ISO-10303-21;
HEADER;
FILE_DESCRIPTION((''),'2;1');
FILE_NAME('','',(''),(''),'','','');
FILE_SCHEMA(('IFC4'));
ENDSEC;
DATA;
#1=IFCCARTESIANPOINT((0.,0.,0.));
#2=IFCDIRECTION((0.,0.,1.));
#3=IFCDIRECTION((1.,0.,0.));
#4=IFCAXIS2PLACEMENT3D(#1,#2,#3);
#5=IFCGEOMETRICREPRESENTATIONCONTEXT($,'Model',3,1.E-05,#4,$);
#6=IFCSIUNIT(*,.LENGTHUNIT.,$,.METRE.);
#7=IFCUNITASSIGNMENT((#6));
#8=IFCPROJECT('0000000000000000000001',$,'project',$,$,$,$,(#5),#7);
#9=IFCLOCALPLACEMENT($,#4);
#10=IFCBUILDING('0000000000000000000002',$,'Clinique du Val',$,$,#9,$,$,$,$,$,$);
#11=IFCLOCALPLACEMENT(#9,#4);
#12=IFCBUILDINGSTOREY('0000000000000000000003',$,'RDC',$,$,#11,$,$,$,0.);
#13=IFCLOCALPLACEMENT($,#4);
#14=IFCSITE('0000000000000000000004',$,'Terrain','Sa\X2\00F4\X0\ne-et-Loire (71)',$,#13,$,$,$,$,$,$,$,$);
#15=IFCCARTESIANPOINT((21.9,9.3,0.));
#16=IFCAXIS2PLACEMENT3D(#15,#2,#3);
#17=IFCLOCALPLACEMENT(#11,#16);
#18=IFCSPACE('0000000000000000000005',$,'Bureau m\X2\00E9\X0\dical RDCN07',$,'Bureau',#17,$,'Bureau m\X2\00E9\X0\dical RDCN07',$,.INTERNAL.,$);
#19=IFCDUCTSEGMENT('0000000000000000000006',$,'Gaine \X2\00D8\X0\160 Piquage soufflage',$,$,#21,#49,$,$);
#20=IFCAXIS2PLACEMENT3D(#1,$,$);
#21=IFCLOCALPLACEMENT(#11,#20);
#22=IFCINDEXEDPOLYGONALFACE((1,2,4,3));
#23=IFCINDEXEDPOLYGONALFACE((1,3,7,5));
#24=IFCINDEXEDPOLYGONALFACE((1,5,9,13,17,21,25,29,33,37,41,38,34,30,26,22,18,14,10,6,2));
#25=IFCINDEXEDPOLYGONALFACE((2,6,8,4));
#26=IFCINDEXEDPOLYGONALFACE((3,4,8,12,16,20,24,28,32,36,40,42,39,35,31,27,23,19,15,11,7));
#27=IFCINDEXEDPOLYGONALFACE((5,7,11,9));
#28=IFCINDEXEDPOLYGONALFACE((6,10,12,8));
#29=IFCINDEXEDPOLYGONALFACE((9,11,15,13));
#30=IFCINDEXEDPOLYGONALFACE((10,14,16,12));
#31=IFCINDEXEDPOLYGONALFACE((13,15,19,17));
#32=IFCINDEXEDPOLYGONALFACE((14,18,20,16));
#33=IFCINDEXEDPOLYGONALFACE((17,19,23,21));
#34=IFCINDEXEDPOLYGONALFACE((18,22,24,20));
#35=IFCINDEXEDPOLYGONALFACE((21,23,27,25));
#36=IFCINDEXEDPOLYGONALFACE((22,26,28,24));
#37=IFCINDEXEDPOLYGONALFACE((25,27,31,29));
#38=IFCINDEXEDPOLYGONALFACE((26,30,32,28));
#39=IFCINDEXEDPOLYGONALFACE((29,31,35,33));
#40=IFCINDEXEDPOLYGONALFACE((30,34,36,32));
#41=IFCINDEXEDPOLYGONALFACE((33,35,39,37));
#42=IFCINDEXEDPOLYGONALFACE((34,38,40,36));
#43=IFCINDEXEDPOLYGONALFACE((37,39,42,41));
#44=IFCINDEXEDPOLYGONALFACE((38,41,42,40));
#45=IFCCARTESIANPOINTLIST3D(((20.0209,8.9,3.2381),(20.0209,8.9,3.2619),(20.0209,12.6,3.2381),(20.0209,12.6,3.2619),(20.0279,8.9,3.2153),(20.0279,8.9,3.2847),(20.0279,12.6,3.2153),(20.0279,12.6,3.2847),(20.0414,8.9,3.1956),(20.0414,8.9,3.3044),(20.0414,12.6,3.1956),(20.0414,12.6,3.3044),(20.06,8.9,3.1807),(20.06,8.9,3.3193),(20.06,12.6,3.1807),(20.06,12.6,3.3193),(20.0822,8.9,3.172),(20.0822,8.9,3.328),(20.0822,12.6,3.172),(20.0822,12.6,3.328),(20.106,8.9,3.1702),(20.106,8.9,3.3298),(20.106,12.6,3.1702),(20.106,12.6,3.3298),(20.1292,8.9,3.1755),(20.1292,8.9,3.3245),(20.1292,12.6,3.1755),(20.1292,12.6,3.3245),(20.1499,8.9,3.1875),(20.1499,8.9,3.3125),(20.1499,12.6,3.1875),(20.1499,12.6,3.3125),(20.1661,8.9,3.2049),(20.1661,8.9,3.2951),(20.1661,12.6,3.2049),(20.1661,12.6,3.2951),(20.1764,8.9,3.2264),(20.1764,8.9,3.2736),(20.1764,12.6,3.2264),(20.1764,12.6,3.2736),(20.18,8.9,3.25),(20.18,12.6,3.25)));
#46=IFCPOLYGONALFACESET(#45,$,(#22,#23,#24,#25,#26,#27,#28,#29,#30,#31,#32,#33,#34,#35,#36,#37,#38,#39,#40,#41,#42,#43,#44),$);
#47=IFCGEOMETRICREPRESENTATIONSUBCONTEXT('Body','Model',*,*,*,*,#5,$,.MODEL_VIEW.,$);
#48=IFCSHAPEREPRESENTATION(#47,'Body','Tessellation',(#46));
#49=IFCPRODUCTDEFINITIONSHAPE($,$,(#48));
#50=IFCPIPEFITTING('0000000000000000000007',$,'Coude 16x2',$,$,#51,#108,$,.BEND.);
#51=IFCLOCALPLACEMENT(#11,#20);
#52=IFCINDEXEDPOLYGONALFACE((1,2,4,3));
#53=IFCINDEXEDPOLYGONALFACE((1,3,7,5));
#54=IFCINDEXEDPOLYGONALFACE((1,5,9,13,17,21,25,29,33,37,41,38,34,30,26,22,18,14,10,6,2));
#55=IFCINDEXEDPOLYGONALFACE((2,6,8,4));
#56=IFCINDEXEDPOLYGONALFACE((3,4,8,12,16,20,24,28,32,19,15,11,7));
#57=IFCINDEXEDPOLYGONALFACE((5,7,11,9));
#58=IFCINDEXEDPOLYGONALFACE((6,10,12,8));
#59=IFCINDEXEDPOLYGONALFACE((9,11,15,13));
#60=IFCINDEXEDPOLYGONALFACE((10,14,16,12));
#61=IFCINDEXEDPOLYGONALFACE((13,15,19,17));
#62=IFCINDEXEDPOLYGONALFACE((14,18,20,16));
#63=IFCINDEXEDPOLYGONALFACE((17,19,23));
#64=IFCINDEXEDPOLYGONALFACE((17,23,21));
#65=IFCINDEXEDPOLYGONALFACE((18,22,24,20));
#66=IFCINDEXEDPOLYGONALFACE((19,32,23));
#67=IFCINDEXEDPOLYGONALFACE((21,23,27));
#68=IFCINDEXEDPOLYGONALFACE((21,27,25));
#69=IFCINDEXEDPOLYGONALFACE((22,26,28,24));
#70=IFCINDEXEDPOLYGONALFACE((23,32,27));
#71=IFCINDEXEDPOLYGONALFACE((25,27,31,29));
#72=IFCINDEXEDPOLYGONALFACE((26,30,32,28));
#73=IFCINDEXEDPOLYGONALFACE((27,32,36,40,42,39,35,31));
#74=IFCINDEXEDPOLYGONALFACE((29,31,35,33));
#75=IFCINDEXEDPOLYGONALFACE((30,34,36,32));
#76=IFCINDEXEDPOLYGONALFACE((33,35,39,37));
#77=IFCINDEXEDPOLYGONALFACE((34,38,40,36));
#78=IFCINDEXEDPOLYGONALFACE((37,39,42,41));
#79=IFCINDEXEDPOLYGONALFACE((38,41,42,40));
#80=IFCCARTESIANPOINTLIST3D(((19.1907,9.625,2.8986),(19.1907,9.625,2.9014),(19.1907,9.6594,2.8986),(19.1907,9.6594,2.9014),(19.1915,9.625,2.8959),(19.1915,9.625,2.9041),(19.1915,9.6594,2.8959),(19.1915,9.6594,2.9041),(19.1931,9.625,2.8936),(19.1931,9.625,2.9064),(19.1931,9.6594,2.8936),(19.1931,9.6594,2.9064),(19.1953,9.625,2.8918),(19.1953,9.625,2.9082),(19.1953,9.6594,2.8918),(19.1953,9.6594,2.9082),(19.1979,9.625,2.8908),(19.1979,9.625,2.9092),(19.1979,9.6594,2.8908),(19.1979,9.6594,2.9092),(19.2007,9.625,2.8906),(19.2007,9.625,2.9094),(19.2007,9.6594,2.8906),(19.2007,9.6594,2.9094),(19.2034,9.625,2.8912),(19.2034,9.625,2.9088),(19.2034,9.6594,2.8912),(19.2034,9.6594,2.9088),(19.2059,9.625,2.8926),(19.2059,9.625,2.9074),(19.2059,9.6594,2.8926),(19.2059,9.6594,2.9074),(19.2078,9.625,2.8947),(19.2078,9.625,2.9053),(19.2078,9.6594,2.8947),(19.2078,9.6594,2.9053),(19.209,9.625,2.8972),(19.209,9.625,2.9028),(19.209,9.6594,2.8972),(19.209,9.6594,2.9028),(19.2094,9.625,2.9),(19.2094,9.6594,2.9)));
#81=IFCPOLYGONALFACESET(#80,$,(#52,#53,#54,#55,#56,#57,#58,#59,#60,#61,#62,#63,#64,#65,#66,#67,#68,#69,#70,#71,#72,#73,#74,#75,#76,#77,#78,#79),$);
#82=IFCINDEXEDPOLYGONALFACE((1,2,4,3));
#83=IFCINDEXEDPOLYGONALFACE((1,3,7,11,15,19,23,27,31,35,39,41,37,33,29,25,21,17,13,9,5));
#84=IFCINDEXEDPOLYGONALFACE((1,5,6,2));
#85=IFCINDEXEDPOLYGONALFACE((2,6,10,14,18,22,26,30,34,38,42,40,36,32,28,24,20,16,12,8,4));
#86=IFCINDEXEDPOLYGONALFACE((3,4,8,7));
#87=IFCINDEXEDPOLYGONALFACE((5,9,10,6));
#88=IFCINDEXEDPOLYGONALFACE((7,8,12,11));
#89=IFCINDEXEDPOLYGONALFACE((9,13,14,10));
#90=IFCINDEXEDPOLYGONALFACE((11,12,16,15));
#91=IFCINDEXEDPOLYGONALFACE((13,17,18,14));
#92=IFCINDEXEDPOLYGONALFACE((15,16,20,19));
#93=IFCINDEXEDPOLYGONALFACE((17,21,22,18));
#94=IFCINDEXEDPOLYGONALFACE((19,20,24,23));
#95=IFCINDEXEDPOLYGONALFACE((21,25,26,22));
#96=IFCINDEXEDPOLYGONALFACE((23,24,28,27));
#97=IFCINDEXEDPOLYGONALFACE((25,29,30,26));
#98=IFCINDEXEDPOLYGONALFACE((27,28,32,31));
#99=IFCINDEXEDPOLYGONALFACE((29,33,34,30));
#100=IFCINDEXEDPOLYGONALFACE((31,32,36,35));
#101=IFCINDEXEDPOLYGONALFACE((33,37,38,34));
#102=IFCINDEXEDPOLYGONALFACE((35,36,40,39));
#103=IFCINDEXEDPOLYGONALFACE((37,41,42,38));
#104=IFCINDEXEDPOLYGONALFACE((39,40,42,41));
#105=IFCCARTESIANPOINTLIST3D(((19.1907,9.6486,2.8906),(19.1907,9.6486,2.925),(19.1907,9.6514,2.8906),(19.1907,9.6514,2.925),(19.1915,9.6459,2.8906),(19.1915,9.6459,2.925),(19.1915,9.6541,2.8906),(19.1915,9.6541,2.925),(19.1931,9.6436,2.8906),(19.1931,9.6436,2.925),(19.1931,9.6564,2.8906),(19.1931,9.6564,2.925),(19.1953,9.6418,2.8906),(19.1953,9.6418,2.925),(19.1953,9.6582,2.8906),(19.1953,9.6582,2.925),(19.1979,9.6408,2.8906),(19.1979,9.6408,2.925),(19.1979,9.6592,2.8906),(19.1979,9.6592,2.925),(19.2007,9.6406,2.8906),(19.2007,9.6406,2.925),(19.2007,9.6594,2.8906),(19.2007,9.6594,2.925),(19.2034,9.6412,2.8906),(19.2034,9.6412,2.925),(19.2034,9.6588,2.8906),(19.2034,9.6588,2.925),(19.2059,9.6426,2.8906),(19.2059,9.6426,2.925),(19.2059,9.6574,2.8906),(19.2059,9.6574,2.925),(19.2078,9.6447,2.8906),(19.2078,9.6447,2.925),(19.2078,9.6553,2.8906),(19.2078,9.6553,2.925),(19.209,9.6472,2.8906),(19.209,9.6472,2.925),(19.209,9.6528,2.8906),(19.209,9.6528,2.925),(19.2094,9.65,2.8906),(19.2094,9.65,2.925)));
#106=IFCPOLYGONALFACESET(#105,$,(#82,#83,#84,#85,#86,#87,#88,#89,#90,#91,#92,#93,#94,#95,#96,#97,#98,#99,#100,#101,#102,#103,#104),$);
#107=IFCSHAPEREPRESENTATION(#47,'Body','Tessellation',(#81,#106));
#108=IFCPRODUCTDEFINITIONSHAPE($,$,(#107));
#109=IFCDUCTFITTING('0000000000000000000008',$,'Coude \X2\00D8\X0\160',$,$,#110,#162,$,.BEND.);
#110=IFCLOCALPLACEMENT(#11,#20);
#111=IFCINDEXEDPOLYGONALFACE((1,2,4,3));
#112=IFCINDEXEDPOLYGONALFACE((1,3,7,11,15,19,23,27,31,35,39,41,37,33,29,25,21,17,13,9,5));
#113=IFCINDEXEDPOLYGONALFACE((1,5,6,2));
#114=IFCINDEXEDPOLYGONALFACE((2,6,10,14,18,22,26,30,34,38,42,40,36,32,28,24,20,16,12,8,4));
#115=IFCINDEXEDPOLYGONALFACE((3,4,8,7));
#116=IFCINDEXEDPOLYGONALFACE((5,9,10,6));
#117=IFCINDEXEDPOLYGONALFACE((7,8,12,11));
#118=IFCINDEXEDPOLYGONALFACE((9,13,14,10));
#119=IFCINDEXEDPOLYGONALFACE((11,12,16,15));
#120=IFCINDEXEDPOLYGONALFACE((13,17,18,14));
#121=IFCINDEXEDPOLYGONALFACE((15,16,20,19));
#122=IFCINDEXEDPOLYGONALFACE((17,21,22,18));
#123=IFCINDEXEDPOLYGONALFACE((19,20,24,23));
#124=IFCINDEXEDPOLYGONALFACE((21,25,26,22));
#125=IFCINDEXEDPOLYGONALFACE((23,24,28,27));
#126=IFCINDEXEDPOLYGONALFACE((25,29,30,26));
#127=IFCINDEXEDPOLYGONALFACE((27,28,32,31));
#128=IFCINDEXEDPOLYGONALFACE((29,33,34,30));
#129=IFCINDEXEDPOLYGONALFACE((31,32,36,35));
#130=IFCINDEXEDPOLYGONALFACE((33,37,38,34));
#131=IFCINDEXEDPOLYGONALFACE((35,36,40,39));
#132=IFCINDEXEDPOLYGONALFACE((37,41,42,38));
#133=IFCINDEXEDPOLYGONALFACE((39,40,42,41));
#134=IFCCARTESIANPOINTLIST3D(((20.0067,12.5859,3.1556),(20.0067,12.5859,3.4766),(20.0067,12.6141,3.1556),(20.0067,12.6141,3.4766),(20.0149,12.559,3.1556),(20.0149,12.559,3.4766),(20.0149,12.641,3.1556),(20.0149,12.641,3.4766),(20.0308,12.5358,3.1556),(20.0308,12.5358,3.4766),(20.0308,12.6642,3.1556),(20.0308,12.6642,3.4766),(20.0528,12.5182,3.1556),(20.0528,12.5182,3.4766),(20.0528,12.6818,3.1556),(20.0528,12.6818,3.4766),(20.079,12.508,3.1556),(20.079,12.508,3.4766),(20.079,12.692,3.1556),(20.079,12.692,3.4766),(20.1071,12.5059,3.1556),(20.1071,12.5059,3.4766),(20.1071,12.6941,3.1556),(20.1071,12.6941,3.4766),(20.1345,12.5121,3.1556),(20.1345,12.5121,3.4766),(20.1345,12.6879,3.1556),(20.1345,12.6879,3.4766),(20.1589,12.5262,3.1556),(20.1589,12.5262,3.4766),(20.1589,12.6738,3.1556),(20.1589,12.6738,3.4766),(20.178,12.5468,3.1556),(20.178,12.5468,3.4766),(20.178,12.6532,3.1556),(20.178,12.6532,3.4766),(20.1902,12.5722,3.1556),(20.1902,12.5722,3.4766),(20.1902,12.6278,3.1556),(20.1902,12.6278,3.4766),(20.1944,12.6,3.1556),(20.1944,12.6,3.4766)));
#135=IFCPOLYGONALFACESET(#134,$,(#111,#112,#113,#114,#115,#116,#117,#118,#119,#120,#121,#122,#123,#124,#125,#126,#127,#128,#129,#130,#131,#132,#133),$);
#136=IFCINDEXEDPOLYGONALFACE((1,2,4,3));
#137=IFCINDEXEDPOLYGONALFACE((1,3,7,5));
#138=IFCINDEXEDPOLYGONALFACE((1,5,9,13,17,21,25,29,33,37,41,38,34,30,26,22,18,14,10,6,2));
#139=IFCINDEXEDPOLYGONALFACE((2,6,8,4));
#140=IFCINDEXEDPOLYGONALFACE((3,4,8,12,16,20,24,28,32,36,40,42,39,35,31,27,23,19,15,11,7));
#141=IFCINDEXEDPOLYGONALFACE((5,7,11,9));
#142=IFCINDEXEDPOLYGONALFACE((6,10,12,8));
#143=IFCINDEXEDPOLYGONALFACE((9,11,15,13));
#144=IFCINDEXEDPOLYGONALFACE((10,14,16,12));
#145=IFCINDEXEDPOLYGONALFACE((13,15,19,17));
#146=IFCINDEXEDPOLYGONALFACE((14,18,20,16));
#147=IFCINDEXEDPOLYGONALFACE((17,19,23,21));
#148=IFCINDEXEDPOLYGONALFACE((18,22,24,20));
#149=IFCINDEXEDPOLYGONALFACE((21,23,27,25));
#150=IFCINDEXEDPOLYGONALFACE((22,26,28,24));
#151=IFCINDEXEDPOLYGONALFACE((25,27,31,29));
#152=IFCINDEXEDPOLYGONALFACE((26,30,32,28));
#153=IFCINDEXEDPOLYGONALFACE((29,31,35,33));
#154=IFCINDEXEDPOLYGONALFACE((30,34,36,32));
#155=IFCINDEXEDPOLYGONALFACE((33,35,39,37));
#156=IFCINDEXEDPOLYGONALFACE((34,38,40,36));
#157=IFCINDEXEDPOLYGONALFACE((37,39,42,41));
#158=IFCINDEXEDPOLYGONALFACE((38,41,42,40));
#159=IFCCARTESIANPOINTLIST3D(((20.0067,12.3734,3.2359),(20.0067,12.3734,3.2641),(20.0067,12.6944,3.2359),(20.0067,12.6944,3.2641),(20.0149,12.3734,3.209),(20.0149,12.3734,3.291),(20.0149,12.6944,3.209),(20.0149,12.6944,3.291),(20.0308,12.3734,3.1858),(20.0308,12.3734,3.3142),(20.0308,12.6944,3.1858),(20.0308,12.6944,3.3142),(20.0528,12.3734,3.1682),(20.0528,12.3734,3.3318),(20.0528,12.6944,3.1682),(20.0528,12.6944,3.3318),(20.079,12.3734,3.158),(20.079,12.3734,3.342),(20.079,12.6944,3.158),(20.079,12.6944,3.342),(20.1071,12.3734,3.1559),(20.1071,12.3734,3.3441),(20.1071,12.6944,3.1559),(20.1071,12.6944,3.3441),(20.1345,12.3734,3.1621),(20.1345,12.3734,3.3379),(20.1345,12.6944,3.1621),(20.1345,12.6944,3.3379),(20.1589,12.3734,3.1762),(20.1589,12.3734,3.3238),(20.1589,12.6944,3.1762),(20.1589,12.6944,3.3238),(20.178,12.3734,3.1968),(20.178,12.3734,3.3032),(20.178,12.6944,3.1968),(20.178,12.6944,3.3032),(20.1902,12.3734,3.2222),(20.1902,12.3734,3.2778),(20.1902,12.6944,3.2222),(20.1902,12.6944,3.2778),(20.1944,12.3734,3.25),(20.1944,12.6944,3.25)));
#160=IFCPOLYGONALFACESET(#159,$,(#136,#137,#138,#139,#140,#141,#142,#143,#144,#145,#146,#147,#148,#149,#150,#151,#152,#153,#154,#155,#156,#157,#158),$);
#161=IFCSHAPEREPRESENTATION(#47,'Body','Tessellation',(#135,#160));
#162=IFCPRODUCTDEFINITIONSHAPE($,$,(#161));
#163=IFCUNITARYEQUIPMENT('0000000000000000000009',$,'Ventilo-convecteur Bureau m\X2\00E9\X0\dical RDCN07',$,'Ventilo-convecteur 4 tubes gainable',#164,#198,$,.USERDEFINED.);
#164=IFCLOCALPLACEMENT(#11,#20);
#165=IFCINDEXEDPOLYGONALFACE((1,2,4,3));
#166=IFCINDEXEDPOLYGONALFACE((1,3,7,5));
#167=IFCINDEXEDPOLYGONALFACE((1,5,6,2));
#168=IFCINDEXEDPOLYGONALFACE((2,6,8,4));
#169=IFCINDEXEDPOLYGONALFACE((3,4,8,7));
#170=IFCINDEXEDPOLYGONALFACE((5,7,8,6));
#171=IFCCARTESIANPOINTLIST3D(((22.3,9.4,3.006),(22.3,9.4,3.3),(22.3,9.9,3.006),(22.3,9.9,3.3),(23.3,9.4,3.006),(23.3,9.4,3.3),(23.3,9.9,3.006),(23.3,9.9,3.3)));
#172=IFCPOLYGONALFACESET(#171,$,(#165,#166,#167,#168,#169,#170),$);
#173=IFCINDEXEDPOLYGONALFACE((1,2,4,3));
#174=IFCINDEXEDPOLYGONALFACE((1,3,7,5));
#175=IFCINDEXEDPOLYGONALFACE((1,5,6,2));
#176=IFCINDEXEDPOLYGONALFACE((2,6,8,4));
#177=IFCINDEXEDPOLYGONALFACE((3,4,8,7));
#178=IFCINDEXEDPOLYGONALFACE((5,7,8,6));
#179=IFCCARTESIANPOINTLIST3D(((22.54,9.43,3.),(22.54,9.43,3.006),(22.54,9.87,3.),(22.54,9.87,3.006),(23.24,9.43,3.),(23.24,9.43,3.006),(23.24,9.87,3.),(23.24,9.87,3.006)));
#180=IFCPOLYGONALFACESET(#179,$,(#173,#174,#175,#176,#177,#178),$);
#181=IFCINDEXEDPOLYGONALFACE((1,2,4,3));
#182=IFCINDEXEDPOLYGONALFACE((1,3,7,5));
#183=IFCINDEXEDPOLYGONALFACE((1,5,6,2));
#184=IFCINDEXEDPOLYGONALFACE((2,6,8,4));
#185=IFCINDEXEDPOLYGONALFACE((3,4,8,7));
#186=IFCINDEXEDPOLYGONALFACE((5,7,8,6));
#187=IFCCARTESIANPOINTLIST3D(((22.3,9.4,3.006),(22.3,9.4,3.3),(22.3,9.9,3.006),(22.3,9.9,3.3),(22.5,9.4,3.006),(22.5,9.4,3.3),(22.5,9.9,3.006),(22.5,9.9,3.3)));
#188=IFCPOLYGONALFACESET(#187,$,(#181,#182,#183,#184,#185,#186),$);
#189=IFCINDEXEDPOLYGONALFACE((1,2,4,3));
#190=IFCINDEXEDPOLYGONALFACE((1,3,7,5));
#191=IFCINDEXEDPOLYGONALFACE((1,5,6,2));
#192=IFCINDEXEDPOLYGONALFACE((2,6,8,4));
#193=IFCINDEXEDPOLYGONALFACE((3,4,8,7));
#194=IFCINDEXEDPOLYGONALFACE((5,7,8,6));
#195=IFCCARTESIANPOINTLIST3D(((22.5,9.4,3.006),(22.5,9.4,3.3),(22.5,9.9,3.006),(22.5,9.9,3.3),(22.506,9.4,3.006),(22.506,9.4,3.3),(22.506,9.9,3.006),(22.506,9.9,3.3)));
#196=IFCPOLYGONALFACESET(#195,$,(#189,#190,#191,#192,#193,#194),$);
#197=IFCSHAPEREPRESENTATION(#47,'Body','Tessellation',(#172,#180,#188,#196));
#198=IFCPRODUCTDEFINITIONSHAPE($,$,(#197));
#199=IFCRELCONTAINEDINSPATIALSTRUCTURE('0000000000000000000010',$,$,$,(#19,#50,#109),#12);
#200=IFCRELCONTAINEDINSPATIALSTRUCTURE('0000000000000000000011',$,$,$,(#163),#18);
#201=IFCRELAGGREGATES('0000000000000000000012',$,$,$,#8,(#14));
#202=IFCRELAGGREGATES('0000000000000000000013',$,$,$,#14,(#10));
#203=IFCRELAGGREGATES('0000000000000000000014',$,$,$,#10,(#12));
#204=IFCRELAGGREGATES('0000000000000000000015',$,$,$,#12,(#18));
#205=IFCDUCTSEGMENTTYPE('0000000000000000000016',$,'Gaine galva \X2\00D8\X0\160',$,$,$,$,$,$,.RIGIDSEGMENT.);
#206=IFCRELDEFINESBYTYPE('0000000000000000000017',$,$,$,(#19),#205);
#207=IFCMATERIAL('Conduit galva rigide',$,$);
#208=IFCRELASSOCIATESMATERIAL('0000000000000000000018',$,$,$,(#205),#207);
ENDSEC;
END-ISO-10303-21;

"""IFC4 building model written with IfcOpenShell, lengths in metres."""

from ifc_helpers import new_model, si_unit, frame, frame_2d, origin_with_axes, place, context, subcontext, project, spatial, rectangle, circle, extrude, material, type_object, element, save


model = new_model("IFC4")

# Units and contexts
model_context = context("Model", 3, precision=1e-05, world=origin_with_axes())
body_context = subcontext(model_context, "Body", "Model", "MODEL_VIEW")
ifc_project = project(units=[si_unit("LENGTHUNIT", "METRE")], contexts=[model_context])

# Site, building, storey
site_placement = place(None, origin_with_axes())
site = spatial("IfcSite", under=ifc_project, at=site_placement, Name="Terrain", Description="Saône-et-Loire (71)")
building_placement = place(None, origin_with_axes())
building = spatial("IfcBuilding", under=site, at=building_placement, Name="Clinique du Val")
storey_placement = place(building_placement, origin_with_axes())
storey = spatial("IfcBuildingStorey", under=building, at=storey_placement, Name="RDC", Elevation=0.0)

# Duct segment
ifc_material_1 = material(Name="Conduit galva rigide")
duct_segment_type = type_object("IfcDuctSegmentType", Name="Gaine galva Ø160", PredefinedType="RIGIDSEGMENT", material=ifc_material_1)
duct_segment_1_placement = place(storey_placement, frame((20.1, 12.6, 3.25), z_axis=(0.0, -1.0, 0.0), x_axis=(1.0, 0.0, 0.0)))
element("IfcDuctSegment", 1, at=duct_segment_1_placement, inside=storey, type_object=duct_segment_type, Name="Gaine Ø160 Piquage soufflage", context=body_context, shape_type="SweptSolid", body=[
    extrude(circle(Radius=0.08), origin_with_axes(), (0.0, 0.0, 1.0), 3.7),
])

# Pipe fitting
pipe_fitting_placement = place(storey_placement, frame((19.2, 9.65, 2.9), z_axis=(0.0, 0.0, 1.0), x_axis=(1.0, 0.0, 0.0)))
element("IfcPipeFitting", 2, at=pipe_fitting_placement, inside=storey, Name="Coude 16x2", PredefinedType="BEND", context=body_context, shape_type="SweptSolid", body=[
    extrude(circle(Radius=0.0094), frame((0.0, 0.0094, 0.0), z_axis=(0.0, -1.0, 0.0), x_axis=(1.0, 0.0, 0.0)), (0.0, 0.0, 1.0), 0.0344),
    extrude(circle(Radius=0.0094), frame((0.0, 0.0, -0.0094), z_axis=(0.0, 0.0, 1.0), x_axis=(1.0, 0.0, 0.0)), (0.0, 0.0, 1.0), 0.0344),
])

# Duct fitting
duct_fitting_placement = place(storey_placement, frame((20.1, 12.6, 3.25), z_axis=(0.0, 0.0, 1.0), x_axis=(1.0, 0.0, 0.0)))
element("IfcDuctFitting", 3, at=duct_fitting_placement, inside=storey, Name="Coude Ø160", PredefinedType="BEND", context=body_context, shape_type="SweptSolid", body=[
    extrude(circle(Radius=0.0944), frame((0.0, 0.0, -0.0944), z_axis=(0.0, 0.0, 1.0), x_axis=(1.0, 0.0, 0.0)), (0.0, 0.0, 1.0), 0.321),
    extrude(circle(Radius=0.0944), frame((0.0, 0.0944, 0.0), z_axis=(0.0, -1.0, 0.0), x_axis=(1.0, 0.0, 0.0)), (0.0, 0.0, 1.0), 0.321),
])

# Shared definitions
space_1_placement = place(storey_placement, frame((21.9, 9.3, 0.0), z_axis=(0.0, 0.0, 1.0), x_axis=(1.0, 0.0, 0.0)))
space_1 = spatial("IfcSpace", under=storey, at=space_1_placement, Name="Bureau médical RDCN07", ObjectType="Bureau", LongName="Bureau médical RDCN07", PredefinedType="INTERNAL")

# Unitary equipment
unitary_equipment_placement = place(space_1_placement, frame((0.4, 0.1, 3.0), z_axis=(0.0, 0.0, 1.0), x_axis=(1.0, 0.0, 0.0)))
element("IfcUnitaryEquipment", 4, at=unitary_equipment_placement, inside=space_1, Name="Ventilo-convecteur Bureau médical RDCN07", ObjectType="Ventilo-convecteur 4 tubes gainable", PredefinedType="USERDEFINED", context=body_context, shape_type="SweptSolid", body=[
    extrude(rectangle(XDim=1.0, YDim=0.5, at=frame_2d((0.5, 0.25))), frame((0.0, 0.0, 0.006), z_axis=(0.0, 0.0, 1.0), x_axis=(1.0, 0.0, 0.0)), (0.0, 0.0, 1.0), 0.294),
    extrude(rectangle(XDim=0.7, YDim=0.44, at=frame_2d((0.35, 0.22))), frame((0.24, 0.03, 0.0), z_axis=(0.0, 0.0, 1.0), x_axis=(1.0, 0.0, 0.0)), (0.0, 0.0, 1.0), 0.006),
    extrude(rectangle(XDim=0.2, YDim=0.5, at=frame_2d((0.1, 0.25))), frame((0.0, 0.0, 0.006), z_axis=(0.0, 0.0, 1.0), x_axis=(1.0, 0.0, 0.0)), (0.0, 0.0, 1.0), 0.294),
    extrude(rectangle(XDim=0.006, YDim=0.5, at=frame_2d((0.003, 0.25))), frame((0.2, 0.0, 0.006), z_axis=(0.0, 0.0, 1.0), x_axis=(1.0, 0.0, 0.0)), (0.0, 0.0, 1.0), 0.294),
])

save(model, "model.ifc")
